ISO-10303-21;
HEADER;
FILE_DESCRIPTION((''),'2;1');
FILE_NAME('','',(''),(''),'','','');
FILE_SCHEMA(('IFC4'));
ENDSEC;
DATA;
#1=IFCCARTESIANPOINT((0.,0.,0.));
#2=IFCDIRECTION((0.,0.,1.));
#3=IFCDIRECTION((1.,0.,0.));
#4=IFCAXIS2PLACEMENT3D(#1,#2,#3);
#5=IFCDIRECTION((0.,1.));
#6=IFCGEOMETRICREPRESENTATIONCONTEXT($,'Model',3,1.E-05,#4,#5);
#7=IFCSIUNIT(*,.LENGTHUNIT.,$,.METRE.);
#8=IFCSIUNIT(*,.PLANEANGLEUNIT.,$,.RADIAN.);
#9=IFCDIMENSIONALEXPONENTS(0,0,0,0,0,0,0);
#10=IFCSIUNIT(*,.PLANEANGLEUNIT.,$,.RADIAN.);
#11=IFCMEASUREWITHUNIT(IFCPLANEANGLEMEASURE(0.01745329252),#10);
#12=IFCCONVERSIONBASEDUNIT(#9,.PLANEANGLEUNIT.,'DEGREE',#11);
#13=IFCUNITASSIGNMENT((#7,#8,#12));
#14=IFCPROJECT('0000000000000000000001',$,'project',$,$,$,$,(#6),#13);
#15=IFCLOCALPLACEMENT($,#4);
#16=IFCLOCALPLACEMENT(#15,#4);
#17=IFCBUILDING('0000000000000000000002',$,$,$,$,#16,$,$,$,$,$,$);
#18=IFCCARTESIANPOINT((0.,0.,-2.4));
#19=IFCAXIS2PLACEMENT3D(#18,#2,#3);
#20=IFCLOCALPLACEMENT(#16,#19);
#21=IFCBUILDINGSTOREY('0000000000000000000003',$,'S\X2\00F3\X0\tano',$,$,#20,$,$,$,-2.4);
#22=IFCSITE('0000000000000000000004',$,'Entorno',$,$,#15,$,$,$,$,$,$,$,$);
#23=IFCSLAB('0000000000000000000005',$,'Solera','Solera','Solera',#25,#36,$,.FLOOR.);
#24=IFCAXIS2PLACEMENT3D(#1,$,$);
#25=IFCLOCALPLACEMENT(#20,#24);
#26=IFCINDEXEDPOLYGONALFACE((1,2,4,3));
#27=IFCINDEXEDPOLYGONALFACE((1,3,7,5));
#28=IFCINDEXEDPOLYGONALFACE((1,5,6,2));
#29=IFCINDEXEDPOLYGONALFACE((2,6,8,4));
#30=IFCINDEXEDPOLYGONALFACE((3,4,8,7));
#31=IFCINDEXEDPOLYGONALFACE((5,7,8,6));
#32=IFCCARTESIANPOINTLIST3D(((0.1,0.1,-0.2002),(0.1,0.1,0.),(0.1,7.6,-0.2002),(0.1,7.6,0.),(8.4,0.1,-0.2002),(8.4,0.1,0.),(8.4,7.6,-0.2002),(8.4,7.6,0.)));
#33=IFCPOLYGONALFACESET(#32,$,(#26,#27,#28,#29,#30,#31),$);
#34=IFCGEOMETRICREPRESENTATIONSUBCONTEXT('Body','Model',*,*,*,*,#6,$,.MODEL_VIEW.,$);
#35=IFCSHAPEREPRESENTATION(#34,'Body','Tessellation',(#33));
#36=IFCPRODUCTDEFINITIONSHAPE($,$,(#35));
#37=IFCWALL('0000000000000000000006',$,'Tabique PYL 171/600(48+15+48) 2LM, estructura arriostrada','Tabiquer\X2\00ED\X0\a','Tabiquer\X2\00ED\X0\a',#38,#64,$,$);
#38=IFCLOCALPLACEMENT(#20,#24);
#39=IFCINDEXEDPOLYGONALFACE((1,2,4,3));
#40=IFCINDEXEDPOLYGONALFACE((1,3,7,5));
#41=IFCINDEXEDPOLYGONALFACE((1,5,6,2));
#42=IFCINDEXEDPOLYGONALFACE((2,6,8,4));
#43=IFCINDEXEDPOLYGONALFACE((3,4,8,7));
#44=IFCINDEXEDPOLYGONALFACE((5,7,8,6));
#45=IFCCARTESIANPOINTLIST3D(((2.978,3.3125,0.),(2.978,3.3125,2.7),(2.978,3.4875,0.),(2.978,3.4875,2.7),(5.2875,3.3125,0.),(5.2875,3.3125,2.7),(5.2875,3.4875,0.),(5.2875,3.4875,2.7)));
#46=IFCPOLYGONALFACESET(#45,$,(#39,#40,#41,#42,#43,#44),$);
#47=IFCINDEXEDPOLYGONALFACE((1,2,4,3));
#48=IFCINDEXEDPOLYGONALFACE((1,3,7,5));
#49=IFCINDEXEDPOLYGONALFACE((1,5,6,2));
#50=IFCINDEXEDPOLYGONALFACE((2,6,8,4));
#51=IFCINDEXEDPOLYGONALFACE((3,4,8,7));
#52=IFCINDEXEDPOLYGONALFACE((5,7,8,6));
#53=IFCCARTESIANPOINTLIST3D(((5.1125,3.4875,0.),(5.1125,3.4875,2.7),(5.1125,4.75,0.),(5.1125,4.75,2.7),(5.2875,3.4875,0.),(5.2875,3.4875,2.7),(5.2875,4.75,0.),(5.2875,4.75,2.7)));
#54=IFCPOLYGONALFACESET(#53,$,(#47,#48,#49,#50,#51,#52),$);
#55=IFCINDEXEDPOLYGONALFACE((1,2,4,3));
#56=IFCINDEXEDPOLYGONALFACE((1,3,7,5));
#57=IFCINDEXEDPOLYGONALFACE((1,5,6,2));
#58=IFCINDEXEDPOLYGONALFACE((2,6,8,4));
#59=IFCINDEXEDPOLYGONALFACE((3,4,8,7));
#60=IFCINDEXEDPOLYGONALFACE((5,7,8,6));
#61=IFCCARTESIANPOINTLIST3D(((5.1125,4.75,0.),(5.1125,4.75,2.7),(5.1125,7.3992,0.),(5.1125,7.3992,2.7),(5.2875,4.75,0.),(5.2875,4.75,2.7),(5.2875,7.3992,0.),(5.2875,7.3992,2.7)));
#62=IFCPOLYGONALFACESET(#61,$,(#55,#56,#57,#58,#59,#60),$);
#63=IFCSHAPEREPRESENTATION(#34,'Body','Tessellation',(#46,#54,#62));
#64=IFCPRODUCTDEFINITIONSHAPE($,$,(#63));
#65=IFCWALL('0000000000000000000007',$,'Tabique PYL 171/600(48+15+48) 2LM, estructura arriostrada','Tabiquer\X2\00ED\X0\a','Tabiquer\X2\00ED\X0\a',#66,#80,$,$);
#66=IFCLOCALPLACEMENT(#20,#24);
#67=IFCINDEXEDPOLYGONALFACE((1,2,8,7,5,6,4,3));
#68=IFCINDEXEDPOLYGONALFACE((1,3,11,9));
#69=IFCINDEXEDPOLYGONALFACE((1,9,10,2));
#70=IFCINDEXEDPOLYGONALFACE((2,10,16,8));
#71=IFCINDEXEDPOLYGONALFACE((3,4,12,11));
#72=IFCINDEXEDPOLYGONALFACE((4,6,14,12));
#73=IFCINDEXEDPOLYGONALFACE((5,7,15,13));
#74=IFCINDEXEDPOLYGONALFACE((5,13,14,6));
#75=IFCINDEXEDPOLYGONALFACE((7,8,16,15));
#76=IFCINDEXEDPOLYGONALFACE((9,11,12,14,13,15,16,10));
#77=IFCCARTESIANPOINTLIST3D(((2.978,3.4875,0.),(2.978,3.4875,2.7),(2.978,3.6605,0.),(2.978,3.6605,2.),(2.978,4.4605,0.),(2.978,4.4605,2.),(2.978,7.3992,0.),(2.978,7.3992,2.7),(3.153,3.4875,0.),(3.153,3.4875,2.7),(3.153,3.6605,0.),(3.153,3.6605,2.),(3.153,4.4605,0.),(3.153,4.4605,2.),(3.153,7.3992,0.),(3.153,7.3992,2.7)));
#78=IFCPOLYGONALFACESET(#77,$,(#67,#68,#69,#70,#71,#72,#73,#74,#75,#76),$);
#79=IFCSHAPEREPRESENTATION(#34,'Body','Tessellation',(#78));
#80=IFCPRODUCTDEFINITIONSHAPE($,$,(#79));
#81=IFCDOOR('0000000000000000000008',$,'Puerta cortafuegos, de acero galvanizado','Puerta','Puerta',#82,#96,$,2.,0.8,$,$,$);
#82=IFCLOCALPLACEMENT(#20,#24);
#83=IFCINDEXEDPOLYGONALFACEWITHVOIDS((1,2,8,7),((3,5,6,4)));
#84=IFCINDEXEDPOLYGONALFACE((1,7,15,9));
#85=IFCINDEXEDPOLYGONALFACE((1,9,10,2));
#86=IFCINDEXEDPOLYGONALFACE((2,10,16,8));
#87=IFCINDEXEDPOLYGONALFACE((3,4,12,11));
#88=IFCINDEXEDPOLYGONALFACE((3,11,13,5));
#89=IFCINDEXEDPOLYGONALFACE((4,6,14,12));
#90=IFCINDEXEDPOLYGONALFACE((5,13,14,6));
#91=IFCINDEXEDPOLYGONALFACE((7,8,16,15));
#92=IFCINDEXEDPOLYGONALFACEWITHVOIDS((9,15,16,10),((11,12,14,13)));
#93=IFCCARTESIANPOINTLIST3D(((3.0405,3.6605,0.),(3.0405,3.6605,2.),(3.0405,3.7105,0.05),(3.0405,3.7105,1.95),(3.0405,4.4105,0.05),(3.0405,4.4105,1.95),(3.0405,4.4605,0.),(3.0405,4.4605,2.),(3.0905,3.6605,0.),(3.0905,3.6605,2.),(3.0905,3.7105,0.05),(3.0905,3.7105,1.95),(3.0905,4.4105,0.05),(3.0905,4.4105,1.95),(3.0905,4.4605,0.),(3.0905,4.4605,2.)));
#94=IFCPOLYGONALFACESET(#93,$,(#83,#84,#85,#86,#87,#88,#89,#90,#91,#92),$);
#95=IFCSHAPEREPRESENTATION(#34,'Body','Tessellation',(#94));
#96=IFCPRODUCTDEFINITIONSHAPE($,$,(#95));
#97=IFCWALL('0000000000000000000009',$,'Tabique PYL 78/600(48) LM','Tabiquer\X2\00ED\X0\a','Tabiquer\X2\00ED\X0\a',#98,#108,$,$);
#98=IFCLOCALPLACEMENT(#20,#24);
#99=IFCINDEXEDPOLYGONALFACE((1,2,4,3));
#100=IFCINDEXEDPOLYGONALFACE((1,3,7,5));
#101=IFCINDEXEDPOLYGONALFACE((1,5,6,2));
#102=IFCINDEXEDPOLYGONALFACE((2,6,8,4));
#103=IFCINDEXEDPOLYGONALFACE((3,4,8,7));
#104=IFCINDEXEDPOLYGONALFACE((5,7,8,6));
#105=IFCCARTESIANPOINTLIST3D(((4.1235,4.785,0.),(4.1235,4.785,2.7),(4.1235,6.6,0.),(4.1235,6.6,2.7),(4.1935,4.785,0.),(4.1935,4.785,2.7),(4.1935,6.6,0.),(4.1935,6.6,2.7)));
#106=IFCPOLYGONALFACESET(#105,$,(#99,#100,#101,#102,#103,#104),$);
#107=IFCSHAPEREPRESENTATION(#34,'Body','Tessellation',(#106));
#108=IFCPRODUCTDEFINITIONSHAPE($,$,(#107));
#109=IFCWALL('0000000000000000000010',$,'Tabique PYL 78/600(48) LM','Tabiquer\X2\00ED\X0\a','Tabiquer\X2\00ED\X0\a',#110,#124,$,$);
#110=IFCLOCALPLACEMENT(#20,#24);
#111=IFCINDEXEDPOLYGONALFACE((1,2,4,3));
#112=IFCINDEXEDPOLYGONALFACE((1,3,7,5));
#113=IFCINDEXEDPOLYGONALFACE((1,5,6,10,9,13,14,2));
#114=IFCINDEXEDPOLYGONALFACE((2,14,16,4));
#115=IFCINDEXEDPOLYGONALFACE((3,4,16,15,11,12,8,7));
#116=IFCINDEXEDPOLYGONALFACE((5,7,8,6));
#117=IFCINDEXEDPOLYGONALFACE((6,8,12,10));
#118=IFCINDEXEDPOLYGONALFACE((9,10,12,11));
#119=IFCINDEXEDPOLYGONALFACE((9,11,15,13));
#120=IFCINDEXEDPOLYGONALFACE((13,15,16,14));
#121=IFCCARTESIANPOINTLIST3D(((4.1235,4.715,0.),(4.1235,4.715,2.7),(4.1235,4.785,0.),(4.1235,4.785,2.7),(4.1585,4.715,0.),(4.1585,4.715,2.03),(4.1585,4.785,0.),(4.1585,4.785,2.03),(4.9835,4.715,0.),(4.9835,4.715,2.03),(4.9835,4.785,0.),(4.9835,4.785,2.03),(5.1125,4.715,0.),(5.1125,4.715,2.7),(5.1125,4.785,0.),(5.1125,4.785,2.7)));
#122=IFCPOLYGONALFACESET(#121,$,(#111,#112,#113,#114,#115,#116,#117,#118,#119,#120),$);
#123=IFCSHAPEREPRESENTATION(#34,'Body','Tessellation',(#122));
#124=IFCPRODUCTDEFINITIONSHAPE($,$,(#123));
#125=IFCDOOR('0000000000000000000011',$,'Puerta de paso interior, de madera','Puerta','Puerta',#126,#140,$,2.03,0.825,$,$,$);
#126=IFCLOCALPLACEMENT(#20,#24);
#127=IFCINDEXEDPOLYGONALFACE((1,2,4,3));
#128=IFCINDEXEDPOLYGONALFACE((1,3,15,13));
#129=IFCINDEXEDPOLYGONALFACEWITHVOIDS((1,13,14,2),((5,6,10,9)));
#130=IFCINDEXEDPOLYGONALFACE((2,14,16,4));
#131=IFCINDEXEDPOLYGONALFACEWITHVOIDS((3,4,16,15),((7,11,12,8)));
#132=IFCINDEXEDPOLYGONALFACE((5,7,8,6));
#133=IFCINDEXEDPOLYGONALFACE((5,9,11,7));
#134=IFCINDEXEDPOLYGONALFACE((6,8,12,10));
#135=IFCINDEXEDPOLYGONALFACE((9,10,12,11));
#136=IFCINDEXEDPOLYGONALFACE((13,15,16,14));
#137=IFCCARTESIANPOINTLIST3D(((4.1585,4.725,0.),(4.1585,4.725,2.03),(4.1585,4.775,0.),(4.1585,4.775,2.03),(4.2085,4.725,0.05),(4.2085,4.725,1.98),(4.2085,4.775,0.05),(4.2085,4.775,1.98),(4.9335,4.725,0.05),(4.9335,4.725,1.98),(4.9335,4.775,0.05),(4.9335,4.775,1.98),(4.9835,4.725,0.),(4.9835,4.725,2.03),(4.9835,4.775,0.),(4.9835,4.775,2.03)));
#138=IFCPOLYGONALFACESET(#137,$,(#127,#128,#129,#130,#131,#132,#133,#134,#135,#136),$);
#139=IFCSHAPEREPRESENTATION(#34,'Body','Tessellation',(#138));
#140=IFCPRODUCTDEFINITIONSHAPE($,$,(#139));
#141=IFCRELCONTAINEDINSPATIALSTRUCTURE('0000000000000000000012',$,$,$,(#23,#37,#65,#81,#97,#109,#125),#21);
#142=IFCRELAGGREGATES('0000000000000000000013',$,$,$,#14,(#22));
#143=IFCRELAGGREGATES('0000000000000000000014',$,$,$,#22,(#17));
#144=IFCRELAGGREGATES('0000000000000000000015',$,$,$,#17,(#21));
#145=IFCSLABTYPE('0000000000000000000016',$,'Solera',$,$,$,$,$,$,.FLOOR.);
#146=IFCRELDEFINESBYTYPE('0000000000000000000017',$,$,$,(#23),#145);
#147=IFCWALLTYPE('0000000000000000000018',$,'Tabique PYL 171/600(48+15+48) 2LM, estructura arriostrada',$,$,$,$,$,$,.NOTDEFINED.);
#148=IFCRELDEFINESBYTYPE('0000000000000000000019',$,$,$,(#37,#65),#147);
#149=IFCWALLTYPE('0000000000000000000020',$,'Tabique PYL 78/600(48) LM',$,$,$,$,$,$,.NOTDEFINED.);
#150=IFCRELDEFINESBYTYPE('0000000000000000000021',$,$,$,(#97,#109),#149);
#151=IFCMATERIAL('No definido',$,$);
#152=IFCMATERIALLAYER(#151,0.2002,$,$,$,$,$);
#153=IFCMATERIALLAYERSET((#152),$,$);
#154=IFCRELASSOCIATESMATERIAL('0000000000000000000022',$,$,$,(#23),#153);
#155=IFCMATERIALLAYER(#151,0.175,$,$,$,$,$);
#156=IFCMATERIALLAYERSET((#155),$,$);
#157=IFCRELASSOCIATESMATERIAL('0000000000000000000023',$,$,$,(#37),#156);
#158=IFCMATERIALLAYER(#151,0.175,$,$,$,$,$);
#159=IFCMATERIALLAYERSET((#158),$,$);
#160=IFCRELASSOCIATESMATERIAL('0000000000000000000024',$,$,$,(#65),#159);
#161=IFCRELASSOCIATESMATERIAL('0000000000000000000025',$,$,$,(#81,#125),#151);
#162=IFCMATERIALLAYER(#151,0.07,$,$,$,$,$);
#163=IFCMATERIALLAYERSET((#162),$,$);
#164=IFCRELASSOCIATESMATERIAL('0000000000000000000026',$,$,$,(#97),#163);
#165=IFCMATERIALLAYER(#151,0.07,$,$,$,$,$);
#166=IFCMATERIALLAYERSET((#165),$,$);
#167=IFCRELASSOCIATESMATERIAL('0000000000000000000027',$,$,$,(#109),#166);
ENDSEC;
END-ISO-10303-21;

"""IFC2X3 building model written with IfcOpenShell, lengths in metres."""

from ifc_helpers import new_model, entity, si_unit, converted_unit, direction, frame, origin_with_axes, origin_2d_with_axis, place, context, subcontext, project, spatial, polyline, rectangle, hollow_rectangle, outline, extrude, shape, material, layer, layer_set, layer_usage, type_object, element, fill, save


model = new_model("IFC2X3")

# Units and contexts
model_context = context("Model", 3, precision=1e-05, world=origin_with_axes(), true_north=direction((0.0, 1.0)))
body_context = subcontext(model_context, "Body", "Model", "MODEL_VIEW")
footprint_context = subcontext(model_context, "FootPrint", "Model", "MODEL_VIEW")
ifc_project = project(units=[si_unit("LENGTHUNIT", "METRE"), si_unit("PLANEANGLEUNIT", "RADIAN"), converted_unit("PLANEANGLEUNIT", "DEGREE", entity("IfcPlaneAngleMeasure", 0.01745329252), si_unit("PLANEANGLEUNIT", "RADIAN"), dimensions=[0, 0, 0, 0, 0, 0, 0])], contexts=[model_context])

# Site, building, storey
site_placement = place(None, origin_with_axes())
site = spatial("IfcSite", under=ifc_project, at=site_placement, Name="Entorno")
building_placement = place(site_placement, origin_with_axes())
building = spatial("IfcBuilding", under=site, at=building_placement)
storey_placement = place(building_placement, frame((0.0, 0.0, -2.4), z_axis=(0.0, 0.0, 1.0), x_axis=(1.0, 0.0, 0.0)))
storey = spatial("IfcBuildingStorey", under=building, at=storey_placement, Name="Sótano", Elevation=-2.4)

# Slab
ifc_material = material(Name="No definido")
ifc_layer_1 = layer(ifc_material, 0.2002)
ifc_layer_set_1 = layer_set([ifc_layer_1])
ifc_layer_usage_1 = layer_usage(ifc_layer_set_1, "AXIS3", "POSITIVE", 0.0)
slab_type = type_object("IfcSlabType", Name="Solera", PredefinedType="FLOOR")
slab_placement = place(storey_placement, frame((0.1, 0.1, -0.2002), z_axis=(0.0, 0.0, 1.0), x_axis=(1.0, 0.0, 0.0)))
element("IfcSlab", 1, at=slab_placement, inside=storey, type_object=slab_type, material=ifc_layer_usage_1, Name="Solera", Description="Solera", ObjectType="Solera", PredefinedType="FLOOR", context=body_context, shape_type="SweptSolid", body=[
    extrude(outline(polyline([(0.0, 0.0), (8.3, 0.0), (8.3, 7.5), (0.0, 7.5), (0.0, 0.0)])), origin_with_axes(), (0.0, 0.0, 1.0), 0.2002),
])

# Wall
ifc_layer_2 = layer(ifc_material, 0.175)
ifc_layer_set_2 = layer_set([ifc_layer_2])
ifc_layer_usage_2 = layer_usage(ifc_layer_set_2, "AXIS2", "POSITIVE", -0.0875)
wall_type_1 = type_object("IfcWallType", Name="Tabique PYL 171/600(48+15+48) 2LM, estructura arriostrada")
wall_1_placement = place(storey_placement, frame((3.0655, 3.4, 0.0), z_axis=(0.0, 0.0, 1.0), x_axis=(1.0, 0.0, 0.0)))
element("IfcWall", 2, at=wall_1_placement, inside=storey, type_object=wall_type_1, material=ifc_layer_usage_2, Name="Tabique PYL 171/600(48+15+48) 2LM, estructura arriostrada", Description="Tabiquería", ObjectType="Tabiquería", context=body_context, shape_type="SolidModel", body=[
    extrude(outline(polyline([(-1.1547, -1.35), (1.1547, -1.35), (1.1547, 1.35), (-1.1547, 1.35), (-1.1547, -1.35)])), frame((1.0673, 0.0875, 1.35), z_axis=(0.0, -1.0, 0.0), x_axis=(1.0, 0.0, 0.0)), (0.0, 0.0, 1.0), 0.175),
    extrude(outline(polyline([(-0.6312, -1.35), (0.6312, -1.35), (0.6312, 1.35), (-0.6312, 1.35), (-0.6312, -1.35)])), frame((2.047, 0.7188, 1.35), z_axis=(1.0, 0.0, 0.0), x_axis=(0.0, 1.0, 0.0)), (0.0, 0.0, 1.0), 0.175),
    extrude(outline(polyline([(-1.3246, -1.35), (1.3246, -1.35), (1.3246, 1.35), (-1.3246, 1.35), (-1.3246, -1.35)])), frame((2.047, 2.6746, 1.35), z_axis=(1.0, 0.0, 0.0), x_axis=(0.0, 1.0, 0.0)), (0.0, 0.0, 1.0), 0.175),
])

# Wall, opening, door
ifc_layer_3 = layer(ifc_material, 0.175)
ifc_layer_set_3 = layer_set([ifc_layer_3])
ifc_layer_usage_3 = layer_usage(ifc_layer_set_3, "AXIS2", "POSITIVE", -0.0875)
wall_2_placement = place(storey_placement, frame((3.0655, 3.4, 0.0), z_axis=(0.0, 0.0, 1.0), x_axis=(0.0, 1.0, 0.0)))
wall_2 = element("IfcWall", 3, at=wall_2_placement, inside=storey, type_object=wall_type_1, material=ifc_layer_usage_3, Name="Tabique PYL 171/600(48+15+48) 2LM, estructura arriostrada", Description="Tabiquería", ObjectType="Tabiquería", context=body_context, shape_type="SolidModel", body=[
    extrude(outline(polyline([(-1.9559, -1.35), (1.9559, -1.35), (1.9559, 1.35), (-1.9559, 1.35), (-1.9559, -1.35)])), frame((2.0434, 0.0875, 1.35), z_axis=(0.0, -1.0, 0.0), x_axis=(1.0, 0.0, 0.0)), (0.0, 0.0, 1.0), 0.175),
])
opening_1_placement = place(wall_2_placement, frame((0.6605, 0.0, 1.0), z_axis=(0.0, 0.0, 1.0), x_axis=(1.0, 0.0, 0.0)))
cartesian_point_1 = entity("IfcCartesianPoint", [-0.4, -0.0875])
opening_1 = element("IfcOpeningElement", 4, at=opening_1_placement, cuts=wall_2, ObjectType="No definido", shapes=[
    shape(body_context, "Body", "SweptSolid", [extrude(rectangle(XDim=2.0, YDim=0.8, at=origin_2d_with_axis()), frame((0.0, -0.0875, 0.0), z_axis=(0.0, 1.0, 0.0), x_axis=(0.0, 0.0, 1.0)), (0.0, 0.0, 1.0), 0.175)]),
    shape(footprint_context, "FootPrint", "GeometricCurveSet", [entity("IfcGeometricCurveSet", [entity("IfcPolyline", [cartesian_point_1, entity("IfcCartesianPoint", [0.4, -0.0875]), entity("IfcCartesianPoint", [0.4, 0.0875]), entity("IfcCartesianPoint", [-0.4, 0.0875]), cartesian_point_1])])]),
])
door_1_placement = place(opening_1_placement, origin_with_axes())
door_1 = element("IfcDoor", 5, at=door_1_placement, inside=storey, material=ifc_material, Name="Puerta cortafuegos, de acero galvanizado", Description="Puerta", ObjectType="Puerta", OverallHeight=2.0, OverallWidth=0.8, context=body_context, shape_type="SweptSolid", body=[
    extrude(hollow_rectangle(XDim=0.8, YDim=2.0, WallThickness=0.05, InnerFilletRadius=0.0, OuterFilletRadius=0.0, at=origin_2d_with_axis()), frame((0.0, 0.025, 0.0), z_axis=(0.0, -1.0, 0.0), x_axis=(1.0, 0.0, 0.0)), (0.0, 0.0, 1.0), 0.05),
])
fill(opening_1, door_1)

# Wall
ifc_layer_4 = layer(ifc_material, 0.07)
ifc_layer_set_4 = layer_set([ifc_layer_4])
ifc_layer_usage_4 = layer_usage(ifc_layer_set_4, "AXIS2", "POSITIVE", -0.035)
wall_type_2 = type_object("IfcWallType", Name="Tabique PYL 78/600(48) LM")
wall_3_placement = place(storey_placement, frame((4.1585, 4.75, 0.0), z_axis=(0.0, 0.0, 1.0), x_axis=(0.0, 1.0, 0.0)))
element("IfcWall", 6, at=wall_3_placement, inside=storey, type_object=wall_type_2, material=ifc_layer_usage_4, Name="Tabique PYL 78/600(48) LM", Description="Tabiquería", ObjectType="Tabiquería", context=body_context, shape_type="SolidModel", body=[
    extrude(outline(polyline([(-0.9075, -1.35), (0.9075, -1.35), (0.9075, 1.35), (-0.9075, 1.35), (-0.9075, -1.35)])), frame((0.9425, 0.035, 1.35), z_axis=(0.0, -1.0, 0.0), x_axis=(1.0, 0.0, 0.0)), (0.0, 0.0, 1.0), 0.07),
])

# Wall, opening, door
ifc_layer_5 = layer(ifc_material, 0.07)
ifc_layer_set_5 = layer_set([ifc_layer_5])
ifc_layer_usage_5 = layer_usage(ifc_layer_set_5, "AXIS2", "POSITIVE", -0.035)
wall_4_placement = place(storey_placement, frame((4.1585, 4.75, 0.0), z_axis=(0.0, 0.0, 1.0), x_axis=(1.0, 0.0, 0.0)))
wall_4 = element("IfcWall", 7, at=wall_4_placement, inside=storey, type_object=wall_type_2, material=ifc_layer_usage_5, Name="Tabique PYL 78/600(48) LM", Description="Tabiquería", ObjectType="Tabiquería", context=body_context, shape_type="SolidModel", body=[
    extrude(outline(polyline([(-0.4945, -1.35), (0.4945, -1.35), (0.4945, 1.35), (-0.4945, 1.35), (-0.4945, -1.35)])), frame((0.4595, 0.035, 1.35), z_axis=(0.0, -1.0, 0.0), x_axis=(1.0, 0.0, 0.0)), (0.0, 0.0, 1.0), 0.07),
])
opening_2_placement = place(wall_4_placement, frame((0.4125, 0.0, 1.015), z_axis=(0.0, 0.0, 1.0), x_axis=(1.0, 0.0, 0.0)))
cartesian_point_2 = entity("IfcCartesianPoint", [-0.4125, -0.035])
opening_2 = element("IfcOpeningElement", 8, at=opening_2_placement, cuts=wall_4, ObjectType="No definido", shapes=[
    shape(body_context, "Body", "SweptSolid", [extrude(rectangle(XDim=2.03, YDim=0.825, at=origin_2d_with_axis()), frame((0.0, -0.035, 0.0), z_axis=(0.0, 1.0, 0.0), x_axis=(0.0, 0.0, 1.0)), (0.0, 0.0, 1.0), 0.07)]),
    shape(footprint_context, "FootPrint", "GeometricCurveSet", [entity("IfcGeometricCurveSet", [entity("IfcPolyline", [cartesian_point_2, entity("IfcCartesianPoint", [0.4125, -0.035]), entity("IfcCartesianPoint", [0.4125, 0.035]), entity("IfcCartesianPoint", [-0.4125, 0.035]), cartesian_point_2])])]),
])
door_2_placement = place(opening_2_placement, origin_with_axes())
door_2 = element("IfcDoor", 9, at=door_2_placement, inside=storey, material=ifc_material, Name="Puerta de paso interior, de madera", Description="Puerta", ObjectType="Puerta", OverallHeight=2.03, OverallWidth=0.825, context=body_context, shape_type="SweptSolid", body=[
    extrude(hollow_rectangle(XDim=0.825, YDim=2.03, WallThickness=0.05, InnerFilletRadius=0.0, OuterFilletRadius=0.0, at=origin_2d_with_axis()), frame((0.0, 0.025, 0.0), z_axis=(0.0, -1.0, 0.0), x_axis=(1.0, 0.0, 0.0)), (0.0, 0.0, 1.0), 0.05),
])
fill(opening_2, door_2)

save(model, "model.ifc")
